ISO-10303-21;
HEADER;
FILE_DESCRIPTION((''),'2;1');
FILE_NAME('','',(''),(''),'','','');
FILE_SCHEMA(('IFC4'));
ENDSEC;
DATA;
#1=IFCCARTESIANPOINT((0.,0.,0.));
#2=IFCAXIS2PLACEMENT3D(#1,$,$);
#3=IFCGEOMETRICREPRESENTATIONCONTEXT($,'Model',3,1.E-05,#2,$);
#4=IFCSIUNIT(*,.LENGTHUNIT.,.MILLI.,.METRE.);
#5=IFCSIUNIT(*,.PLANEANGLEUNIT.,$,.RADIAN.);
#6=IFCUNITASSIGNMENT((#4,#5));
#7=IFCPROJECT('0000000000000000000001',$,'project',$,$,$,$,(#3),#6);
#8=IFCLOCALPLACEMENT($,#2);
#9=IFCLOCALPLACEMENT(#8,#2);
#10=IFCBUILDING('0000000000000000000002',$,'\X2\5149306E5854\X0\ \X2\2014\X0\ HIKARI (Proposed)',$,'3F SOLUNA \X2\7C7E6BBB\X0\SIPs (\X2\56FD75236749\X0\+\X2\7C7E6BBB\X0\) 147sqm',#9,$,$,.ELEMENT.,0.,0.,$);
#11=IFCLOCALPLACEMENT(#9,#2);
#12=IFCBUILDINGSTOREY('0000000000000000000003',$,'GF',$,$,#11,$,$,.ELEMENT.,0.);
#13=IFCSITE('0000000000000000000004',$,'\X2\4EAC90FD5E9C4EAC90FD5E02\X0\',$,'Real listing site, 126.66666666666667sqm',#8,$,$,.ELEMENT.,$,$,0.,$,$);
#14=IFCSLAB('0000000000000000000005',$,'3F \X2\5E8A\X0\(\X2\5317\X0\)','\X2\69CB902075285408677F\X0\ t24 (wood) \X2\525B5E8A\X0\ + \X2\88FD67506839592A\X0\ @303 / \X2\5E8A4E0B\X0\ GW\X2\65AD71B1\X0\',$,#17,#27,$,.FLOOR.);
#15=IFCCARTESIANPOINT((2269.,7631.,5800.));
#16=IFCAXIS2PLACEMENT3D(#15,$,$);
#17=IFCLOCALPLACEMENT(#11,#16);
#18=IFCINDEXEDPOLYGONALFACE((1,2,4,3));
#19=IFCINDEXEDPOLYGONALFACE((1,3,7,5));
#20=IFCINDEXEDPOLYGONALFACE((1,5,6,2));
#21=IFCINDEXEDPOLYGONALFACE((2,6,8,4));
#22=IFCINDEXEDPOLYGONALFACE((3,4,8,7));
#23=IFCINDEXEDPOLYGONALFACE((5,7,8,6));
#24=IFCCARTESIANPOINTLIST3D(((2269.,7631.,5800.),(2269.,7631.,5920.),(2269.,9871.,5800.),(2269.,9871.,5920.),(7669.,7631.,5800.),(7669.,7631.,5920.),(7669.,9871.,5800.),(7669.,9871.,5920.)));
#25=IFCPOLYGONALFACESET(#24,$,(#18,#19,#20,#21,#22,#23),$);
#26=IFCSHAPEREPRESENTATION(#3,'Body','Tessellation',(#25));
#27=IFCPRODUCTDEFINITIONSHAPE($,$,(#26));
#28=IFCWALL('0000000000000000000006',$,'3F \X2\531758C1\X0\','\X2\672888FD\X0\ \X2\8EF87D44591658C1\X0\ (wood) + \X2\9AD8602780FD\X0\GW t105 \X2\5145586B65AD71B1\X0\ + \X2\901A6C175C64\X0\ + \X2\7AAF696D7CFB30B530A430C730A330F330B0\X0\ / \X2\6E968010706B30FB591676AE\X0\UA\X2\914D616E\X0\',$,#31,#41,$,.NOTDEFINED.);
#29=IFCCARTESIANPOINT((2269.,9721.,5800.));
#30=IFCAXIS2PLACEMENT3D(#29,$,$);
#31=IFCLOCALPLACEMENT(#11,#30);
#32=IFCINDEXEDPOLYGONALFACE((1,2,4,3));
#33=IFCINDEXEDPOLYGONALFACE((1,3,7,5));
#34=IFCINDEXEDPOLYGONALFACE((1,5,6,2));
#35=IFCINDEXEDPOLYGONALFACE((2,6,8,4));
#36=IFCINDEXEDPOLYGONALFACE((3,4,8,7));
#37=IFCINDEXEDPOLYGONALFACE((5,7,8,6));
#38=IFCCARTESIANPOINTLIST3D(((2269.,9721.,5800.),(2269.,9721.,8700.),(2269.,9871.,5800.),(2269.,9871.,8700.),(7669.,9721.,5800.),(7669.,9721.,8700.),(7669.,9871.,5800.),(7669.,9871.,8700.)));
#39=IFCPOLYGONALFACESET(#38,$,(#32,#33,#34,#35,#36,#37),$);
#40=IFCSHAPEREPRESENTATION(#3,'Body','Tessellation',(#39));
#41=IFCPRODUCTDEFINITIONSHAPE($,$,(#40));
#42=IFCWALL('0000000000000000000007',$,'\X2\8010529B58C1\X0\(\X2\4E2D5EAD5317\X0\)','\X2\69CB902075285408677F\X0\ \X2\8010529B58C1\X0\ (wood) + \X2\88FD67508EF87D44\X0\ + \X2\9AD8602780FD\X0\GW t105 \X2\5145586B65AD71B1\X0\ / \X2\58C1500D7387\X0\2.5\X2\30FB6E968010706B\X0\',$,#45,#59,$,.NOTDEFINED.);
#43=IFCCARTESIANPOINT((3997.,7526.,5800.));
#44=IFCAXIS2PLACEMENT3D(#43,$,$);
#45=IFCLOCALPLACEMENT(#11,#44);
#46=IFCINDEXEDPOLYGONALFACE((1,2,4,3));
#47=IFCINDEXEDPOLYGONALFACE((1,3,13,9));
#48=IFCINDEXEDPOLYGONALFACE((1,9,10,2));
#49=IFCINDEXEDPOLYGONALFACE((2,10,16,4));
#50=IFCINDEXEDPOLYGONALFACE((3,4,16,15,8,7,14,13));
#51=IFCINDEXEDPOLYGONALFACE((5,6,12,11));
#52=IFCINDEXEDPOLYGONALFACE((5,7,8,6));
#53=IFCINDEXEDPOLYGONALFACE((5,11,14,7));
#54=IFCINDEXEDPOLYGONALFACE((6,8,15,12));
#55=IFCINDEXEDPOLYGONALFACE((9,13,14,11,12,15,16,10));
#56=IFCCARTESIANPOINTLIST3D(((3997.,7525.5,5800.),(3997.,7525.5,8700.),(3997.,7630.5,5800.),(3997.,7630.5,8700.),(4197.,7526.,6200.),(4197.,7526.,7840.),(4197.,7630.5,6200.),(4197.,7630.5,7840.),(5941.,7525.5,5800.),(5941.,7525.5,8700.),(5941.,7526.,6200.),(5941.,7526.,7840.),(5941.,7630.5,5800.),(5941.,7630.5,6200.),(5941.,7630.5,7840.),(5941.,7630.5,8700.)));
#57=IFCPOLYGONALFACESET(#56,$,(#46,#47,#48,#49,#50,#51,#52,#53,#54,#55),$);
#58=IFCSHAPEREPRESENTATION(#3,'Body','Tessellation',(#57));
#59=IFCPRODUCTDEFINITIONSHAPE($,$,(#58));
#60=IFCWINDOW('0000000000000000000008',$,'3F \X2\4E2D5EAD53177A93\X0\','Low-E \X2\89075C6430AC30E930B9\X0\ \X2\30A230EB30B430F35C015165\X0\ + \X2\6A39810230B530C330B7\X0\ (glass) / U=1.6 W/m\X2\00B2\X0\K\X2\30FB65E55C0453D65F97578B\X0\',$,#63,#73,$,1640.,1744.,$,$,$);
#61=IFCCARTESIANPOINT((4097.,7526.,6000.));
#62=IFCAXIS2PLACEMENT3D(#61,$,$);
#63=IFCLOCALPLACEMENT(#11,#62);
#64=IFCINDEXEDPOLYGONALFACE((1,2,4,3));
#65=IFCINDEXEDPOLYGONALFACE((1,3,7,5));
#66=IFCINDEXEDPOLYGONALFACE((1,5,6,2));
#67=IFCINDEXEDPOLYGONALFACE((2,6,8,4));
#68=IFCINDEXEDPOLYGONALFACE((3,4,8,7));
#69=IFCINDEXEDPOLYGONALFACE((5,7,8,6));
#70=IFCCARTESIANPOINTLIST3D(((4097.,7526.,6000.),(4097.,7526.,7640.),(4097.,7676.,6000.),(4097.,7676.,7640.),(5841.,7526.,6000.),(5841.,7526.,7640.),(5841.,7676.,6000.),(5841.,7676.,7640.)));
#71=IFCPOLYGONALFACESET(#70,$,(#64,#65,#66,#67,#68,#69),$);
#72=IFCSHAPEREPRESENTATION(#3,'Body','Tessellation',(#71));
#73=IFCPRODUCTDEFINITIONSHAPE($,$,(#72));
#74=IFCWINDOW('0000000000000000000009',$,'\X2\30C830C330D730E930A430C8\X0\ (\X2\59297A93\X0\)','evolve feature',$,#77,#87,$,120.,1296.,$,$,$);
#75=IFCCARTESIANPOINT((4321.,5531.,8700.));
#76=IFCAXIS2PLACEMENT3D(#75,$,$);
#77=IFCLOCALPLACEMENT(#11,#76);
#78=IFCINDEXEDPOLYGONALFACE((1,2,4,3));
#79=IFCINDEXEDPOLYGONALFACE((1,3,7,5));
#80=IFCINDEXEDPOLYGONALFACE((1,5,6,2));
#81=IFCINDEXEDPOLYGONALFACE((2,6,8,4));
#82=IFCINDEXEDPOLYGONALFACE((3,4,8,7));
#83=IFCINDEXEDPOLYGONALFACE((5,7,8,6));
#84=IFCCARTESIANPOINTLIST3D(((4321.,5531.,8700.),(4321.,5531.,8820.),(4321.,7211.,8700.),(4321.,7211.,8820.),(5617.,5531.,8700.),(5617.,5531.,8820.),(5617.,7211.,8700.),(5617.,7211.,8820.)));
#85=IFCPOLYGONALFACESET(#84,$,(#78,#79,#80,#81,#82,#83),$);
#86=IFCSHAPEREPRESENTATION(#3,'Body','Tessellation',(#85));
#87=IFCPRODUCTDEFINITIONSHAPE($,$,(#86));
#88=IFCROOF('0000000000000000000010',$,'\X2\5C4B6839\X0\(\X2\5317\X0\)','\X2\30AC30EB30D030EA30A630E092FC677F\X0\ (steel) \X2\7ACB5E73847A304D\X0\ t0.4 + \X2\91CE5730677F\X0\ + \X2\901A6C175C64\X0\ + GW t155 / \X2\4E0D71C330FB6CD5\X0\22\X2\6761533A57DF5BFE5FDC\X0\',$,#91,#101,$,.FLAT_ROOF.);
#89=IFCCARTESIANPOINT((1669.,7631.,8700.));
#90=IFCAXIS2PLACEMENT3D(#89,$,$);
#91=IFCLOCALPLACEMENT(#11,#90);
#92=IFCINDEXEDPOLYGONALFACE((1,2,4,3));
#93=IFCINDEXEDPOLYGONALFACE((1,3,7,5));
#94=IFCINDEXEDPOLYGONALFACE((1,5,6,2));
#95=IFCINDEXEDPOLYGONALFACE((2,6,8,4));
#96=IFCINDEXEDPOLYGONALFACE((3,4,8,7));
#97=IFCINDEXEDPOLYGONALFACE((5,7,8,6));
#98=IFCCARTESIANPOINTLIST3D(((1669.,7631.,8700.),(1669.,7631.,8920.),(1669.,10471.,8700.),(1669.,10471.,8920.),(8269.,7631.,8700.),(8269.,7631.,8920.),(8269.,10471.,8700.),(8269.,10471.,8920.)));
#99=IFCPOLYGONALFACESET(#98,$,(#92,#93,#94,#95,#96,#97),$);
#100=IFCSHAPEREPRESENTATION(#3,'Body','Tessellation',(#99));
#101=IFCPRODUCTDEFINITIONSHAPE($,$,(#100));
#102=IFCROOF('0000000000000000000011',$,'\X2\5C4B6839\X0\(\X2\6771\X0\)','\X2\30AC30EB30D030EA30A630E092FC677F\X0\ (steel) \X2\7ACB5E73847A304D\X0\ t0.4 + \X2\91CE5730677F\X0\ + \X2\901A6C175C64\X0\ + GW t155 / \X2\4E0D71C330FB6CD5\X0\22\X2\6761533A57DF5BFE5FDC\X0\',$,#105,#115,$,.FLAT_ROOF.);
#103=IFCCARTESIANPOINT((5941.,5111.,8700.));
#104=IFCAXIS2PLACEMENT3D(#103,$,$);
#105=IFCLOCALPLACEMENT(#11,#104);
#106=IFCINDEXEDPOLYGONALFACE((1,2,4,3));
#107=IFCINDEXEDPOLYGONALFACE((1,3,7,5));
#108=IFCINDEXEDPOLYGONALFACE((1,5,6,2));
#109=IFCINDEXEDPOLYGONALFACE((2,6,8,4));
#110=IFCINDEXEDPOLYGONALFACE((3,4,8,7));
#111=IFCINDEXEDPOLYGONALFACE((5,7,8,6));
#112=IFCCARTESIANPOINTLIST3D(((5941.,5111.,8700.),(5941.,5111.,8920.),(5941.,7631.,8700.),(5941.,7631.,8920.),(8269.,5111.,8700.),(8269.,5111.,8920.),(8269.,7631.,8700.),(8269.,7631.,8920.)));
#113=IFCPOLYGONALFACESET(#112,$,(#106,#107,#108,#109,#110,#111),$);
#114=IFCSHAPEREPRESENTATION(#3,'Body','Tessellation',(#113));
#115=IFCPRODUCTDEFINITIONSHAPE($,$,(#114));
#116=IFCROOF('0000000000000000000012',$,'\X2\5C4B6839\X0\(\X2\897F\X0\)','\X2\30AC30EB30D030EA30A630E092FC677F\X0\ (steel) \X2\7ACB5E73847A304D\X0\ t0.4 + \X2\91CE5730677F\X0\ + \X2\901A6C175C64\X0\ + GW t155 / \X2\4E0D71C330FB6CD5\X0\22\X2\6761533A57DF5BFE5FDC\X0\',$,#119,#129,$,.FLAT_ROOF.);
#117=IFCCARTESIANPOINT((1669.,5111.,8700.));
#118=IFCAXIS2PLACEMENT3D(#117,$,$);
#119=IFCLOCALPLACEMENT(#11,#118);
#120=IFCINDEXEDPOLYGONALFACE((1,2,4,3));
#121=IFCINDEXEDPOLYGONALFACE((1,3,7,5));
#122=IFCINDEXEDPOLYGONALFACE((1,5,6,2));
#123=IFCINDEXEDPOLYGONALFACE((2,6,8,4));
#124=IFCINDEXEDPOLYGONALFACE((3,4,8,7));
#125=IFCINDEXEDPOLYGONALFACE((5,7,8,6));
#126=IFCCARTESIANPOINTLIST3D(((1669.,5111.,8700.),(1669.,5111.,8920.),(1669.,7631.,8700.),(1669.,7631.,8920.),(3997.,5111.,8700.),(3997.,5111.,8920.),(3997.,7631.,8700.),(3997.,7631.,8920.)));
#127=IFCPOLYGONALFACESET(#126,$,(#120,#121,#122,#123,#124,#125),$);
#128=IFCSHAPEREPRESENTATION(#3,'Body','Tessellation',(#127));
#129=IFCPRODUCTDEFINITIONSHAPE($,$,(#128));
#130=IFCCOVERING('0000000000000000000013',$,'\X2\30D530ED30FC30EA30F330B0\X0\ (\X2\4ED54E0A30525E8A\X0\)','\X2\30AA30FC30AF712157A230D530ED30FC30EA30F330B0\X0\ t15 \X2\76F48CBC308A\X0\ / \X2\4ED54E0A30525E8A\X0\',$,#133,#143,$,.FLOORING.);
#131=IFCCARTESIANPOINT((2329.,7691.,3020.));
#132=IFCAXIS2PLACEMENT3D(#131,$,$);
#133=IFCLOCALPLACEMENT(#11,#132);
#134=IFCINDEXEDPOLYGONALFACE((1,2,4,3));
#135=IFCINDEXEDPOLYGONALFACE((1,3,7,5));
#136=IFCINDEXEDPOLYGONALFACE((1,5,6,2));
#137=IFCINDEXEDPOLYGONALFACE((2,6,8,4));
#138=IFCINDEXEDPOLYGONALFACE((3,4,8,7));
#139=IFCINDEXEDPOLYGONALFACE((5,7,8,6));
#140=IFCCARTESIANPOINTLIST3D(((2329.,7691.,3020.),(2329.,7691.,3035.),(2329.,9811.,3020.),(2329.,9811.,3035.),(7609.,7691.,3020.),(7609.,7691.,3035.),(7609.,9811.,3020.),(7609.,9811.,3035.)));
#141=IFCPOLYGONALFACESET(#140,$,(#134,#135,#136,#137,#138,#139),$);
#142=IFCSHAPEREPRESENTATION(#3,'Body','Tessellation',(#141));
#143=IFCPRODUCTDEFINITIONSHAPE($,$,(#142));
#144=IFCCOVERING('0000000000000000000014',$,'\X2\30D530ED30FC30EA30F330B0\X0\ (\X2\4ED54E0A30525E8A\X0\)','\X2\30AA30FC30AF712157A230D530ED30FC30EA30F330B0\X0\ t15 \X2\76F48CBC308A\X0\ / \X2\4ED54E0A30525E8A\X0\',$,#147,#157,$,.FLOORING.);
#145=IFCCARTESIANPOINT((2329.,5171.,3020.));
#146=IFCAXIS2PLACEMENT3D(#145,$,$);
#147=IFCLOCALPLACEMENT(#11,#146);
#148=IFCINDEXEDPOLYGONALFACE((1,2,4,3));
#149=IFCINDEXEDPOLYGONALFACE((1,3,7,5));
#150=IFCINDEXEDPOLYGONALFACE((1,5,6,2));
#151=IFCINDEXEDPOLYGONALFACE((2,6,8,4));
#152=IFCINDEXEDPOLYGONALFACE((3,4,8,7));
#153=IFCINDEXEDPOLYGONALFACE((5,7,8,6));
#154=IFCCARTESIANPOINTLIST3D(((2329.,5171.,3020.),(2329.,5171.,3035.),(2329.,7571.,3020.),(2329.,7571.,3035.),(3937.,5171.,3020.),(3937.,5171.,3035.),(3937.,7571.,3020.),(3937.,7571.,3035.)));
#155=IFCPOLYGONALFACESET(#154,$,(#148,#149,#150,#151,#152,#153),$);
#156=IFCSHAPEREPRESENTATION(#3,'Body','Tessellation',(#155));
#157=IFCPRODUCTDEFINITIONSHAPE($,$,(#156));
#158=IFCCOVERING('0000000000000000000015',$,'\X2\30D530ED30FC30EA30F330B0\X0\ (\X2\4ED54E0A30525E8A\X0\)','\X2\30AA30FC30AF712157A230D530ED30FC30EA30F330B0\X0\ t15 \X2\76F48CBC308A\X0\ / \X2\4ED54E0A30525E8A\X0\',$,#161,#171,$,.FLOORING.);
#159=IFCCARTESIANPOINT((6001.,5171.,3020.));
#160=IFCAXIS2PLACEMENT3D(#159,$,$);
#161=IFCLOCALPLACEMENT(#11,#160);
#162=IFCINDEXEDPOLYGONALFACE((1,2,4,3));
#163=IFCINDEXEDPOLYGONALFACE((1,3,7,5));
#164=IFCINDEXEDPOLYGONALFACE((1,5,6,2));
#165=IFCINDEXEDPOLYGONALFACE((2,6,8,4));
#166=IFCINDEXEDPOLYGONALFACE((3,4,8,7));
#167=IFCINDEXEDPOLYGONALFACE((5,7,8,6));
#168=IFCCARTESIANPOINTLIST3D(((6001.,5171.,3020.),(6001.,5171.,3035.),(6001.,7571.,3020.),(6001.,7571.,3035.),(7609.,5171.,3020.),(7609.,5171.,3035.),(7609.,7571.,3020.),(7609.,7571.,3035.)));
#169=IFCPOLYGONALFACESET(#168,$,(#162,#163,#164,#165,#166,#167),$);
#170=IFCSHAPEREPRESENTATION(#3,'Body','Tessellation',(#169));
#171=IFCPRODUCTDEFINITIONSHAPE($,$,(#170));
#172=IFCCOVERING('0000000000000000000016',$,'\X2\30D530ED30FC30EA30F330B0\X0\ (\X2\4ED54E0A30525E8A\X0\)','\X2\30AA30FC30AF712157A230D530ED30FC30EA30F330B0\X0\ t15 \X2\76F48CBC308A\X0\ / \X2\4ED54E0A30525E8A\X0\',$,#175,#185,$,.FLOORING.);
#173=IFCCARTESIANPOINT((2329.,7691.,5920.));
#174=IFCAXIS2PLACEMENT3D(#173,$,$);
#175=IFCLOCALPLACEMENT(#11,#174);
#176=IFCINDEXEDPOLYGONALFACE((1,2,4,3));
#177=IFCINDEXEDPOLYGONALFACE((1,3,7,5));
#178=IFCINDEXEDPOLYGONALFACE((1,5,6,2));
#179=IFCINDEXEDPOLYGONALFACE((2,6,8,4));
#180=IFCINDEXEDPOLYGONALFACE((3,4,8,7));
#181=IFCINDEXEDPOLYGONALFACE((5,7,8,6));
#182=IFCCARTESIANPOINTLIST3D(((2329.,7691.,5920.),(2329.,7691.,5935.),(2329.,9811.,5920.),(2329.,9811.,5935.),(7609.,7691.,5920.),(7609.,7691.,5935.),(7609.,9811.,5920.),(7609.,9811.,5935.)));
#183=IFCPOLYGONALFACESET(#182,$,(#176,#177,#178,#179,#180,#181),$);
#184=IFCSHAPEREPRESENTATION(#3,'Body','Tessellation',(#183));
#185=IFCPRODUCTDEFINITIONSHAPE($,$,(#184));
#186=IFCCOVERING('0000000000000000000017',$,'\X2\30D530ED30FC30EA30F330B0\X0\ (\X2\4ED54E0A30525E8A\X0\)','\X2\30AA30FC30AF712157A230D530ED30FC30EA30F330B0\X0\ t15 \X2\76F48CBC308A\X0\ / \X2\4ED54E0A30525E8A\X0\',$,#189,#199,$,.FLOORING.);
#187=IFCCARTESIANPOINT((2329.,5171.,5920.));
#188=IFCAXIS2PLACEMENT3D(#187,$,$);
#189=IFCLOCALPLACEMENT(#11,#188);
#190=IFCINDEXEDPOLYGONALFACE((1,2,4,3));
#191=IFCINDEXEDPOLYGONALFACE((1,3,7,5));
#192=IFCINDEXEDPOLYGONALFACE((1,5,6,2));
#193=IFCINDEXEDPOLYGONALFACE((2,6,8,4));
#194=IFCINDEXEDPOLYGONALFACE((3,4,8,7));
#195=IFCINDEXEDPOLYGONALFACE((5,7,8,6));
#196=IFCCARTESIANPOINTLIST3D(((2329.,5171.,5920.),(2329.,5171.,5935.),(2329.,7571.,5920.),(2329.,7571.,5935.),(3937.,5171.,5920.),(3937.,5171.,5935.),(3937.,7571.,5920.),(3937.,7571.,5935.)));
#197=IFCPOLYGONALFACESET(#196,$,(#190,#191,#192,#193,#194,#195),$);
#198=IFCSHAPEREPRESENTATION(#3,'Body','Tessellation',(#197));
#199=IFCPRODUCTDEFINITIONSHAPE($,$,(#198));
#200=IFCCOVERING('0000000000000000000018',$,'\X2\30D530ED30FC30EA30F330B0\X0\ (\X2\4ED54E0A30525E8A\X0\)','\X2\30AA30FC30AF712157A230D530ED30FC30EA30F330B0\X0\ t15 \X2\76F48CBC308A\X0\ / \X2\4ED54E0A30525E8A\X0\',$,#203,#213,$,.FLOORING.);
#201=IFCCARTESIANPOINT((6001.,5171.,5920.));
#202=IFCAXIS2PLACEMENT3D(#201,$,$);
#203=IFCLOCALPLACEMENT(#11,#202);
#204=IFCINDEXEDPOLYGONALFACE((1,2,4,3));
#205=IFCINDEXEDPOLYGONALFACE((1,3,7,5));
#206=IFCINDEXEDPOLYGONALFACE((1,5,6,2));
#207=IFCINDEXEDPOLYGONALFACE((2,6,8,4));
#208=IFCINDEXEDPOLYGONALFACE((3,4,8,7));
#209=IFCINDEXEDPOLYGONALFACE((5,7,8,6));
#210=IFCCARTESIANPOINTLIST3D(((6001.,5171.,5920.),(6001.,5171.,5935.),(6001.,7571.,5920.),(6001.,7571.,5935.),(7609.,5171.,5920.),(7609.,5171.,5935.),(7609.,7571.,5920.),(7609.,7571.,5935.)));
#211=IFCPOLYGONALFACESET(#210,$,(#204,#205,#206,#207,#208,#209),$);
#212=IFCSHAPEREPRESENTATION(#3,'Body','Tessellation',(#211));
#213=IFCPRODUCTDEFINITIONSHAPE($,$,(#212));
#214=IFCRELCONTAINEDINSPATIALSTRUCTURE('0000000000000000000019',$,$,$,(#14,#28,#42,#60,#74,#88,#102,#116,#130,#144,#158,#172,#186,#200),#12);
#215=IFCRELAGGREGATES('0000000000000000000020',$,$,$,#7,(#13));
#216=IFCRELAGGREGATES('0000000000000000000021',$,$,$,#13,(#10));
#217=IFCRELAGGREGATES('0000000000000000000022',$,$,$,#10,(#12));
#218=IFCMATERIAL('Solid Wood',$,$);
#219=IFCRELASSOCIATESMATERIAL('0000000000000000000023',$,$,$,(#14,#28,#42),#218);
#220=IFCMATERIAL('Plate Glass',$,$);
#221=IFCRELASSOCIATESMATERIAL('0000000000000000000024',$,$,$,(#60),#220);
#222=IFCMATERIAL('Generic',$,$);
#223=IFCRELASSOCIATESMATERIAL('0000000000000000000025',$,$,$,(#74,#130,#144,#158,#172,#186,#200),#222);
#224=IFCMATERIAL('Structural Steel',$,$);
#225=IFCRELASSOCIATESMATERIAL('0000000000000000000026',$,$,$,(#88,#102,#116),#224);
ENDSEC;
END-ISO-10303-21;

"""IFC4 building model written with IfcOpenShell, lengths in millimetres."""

from ifc_helpers import new_model, si_unit, frame, frame_2d, origin, place, context, project, spatial, rectangle, extrude, material, element, fill, save


model = new_model("IFC4")

# Units and contexts
model_context = context("Model", 3, precision=1e-05, world=origin())
ifc_project = project(units=[si_unit("LENGTHUNIT", "METRE", prefix="MILLI"), si_unit("PLANEANGLEUNIT", "RADIAN")], contexts=[model_context])

# Site, building, storey
site_placement = place(None, origin())
site = spatial("IfcSite", under=ifc_project, at=site_placement, Name="京都府京都市", ObjectType="Real listing site, 126.66666666666667sqm", CompositionType="ELEMENT", RefElevation=0.0)
building_placement = place(site_placement, origin())
building = spatial("IfcBuilding", under=site, at=building_placement, Name="光の塔 — HIKARI (Proposed)", ObjectType="3F SOLUNA 籾殻SIPs (国産杉+籾殻) 147sqm", CompositionType="ELEMENT", ElevationOfRefHeight=0.0, ElevationOfTerrain=0.0)
storey_placement = place(building_placement, origin())
storey = spatial("IfcBuildingStorey", under=building, at=storey_placement, Name="GF", CompositionType="ELEMENT", Elevation=0.0)

# Slab
ifc_material_1 = material(Name="Solid Wood")
slab_placement = place(storey_placement, frame((2269.0, 7631.0, 5800.0)))
element("IfcSlab", 1, at=slab_placement, inside=storey, material=ifc_material_1, Name="3F 床(北)", Description="構造用合板 t24 (wood) 剛床 + 製材根太 @303 / 床下 GW断熱", PredefinedType="FLOOR", context=model_context, shape_type="SweptSolid", body=[
    extrude(rectangle(XDim=5400.0, YDim=2240.0, at=frame_2d((2700.0, 1120.0))), frame((2269.0, 7631.0, 5800.0)), (0.0, 0.0, 1.0), 120.0),
])

# Wall
wall_1_placement = place(storey_placement, frame((2269.0, 9721.0, 5800.0)))
element("IfcWall", 2, at=wall_1_placement, inside=storey, material=ifc_material_1, Name="3F 北壁", Description="木製 軸組外壁 (wood) + 高性能GW t105 充填断熱 + 通気層 + 窯業系サイディング / 準耐火・外皮UA配慮", PredefinedType="NOTDEFINED", context=model_context, shape_type="SweptSolid", body=[
    extrude(rectangle(XDim=5400.0, YDim=150.0, at=frame_2d((2700.0, 75.0))), frame((2269.0, 9721.0, 5800.0)), (0.0, 0.0, 1.0), 2900.0),
])

# Wall, opening, window
wall_2_placement = place(storey_placement, frame((3997.0, 7526.0, 5800.0)))
wall_2 = element("IfcWall", 3, at=wall_2_placement, inside=storey, material=ifc_material_1, Name="耐力壁(中庭北)", Description="構造用合板 耐力壁 (wood) + 製材軸組 + 高性能GW t105 充填断熱 / 壁倍率2.5・準耐火", PredefinedType="NOTDEFINED", context=model_context, shape_type="SweptSolid", body=[
    extrude(rectangle(XDim=1944.0, YDim=105.0, at=frame_2d((972.0, 52.0))), frame((3997.0, 7526.0, 5800.0)), (0.0, 0.0, 1.0), 2900.0),
])
opening_placement = place(storey_placement, frame((4097.0, 7526.0, 6000.0)))
opening = element("IfcOpeningElement", 4, at=opening_placement, cuts=wall_2, PredefinedType="NOTDEFINED", context=model_context, shape_type="SweptSolid", body=[
    extrude(rectangle(XDim=1744.0, YDim=150.0, at=frame_2d((872.0, 75.0))), frame((4097.0, 7526.0, 6000.0)), (0.0, 0.0, 1.0), 1640.0),
])
ifc_material_2 = material(Name="Plate Glass")
window_1_placement = place(storey_placement, frame((4097.0, 7526.0, 6000.0)))
window_1 = element("IfcWindow", 5, at=window_1_placement, inside=storey, material=ifc_material_2, Name="3F 中庭北窓", Description="Low-E 複層ガラス アルゴン封入 + 樹脂サッシ (glass) / U=1.6 W/m²K・日射取得型", OverallHeight=1640.0, OverallWidth=1744.0, context=model_context, shape_type="SweptSolid", body=[
    extrude(rectangle(XDim=1744.0, YDim=150.0, at=frame_2d((872.0, 75.0))), frame((4097.0, 7526.0, 6000.0)), (0.0, 0.0, 1.0), 1640.0),
])
fill(opening, window_1)

# Window
ifc_material_3 = material(Name="Generic")
window_2_placement = place(storey_placement, frame((4321.0, 5531.0, 8700.0)))
element("IfcWindow", 6, at=window_2_placement, inside=storey, material=ifc_material_3, Name="トップライト (天窓)", Description="evolve feature", OverallHeight=120.0, OverallWidth=1296.0, context=model_context, shape_type="SweptSolid", body=[
    extrude(rectangle(XDim=1296.0, YDim=1680.0, at=frame_2d((648.0, 840.0))), frame((4321.0, 5531.0, 8700.0)), (0.0, 0.0, 1.0), 120.0),
])

# Roofs
ifc_material_4 = material(Name="Structural Steel")
roof_1_placement = place(storey_placement, frame((1669.0, 7631.0, 8700.0)))
element("IfcRoof", 7, at=roof_1_placement, inside=storey, material=ifc_material_4, Name="屋根(北)", Description="ガルバリウム鋼板 (steel) 立平葺き t0.4 + 野地板 + 通気層 + GW t155 / 不燃・法22条区域対応", PredefinedType="FLAT_ROOF", context=model_context, shape_type="SweptSolid", body=[
    extrude(rectangle(XDim=6600.0, YDim=2840.0, at=frame_2d((3300.0, 1420.0))), frame((1669.0, 7631.0, 8700.0)), (0.0, 0.0, 1.0), 220.0),
])
roof_2_placement = place(storey_placement, frame((5941.0, 5111.0, 8700.0)))
element("IfcRoof", 8, at=roof_2_placement, inside=storey, material=ifc_material_4, Name="屋根(東)", Description="ガルバリウム鋼板 (steel) 立平葺き t0.4 + 野地板 + 通気層 + GW t155 / 不燃・法22条区域対応", PredefinedType="FLAT_ROOF", context=model_context, shape_type="SweptSolid", body=[
    extrude(rectangle(XDim=2328.0, YDim=2520.0, at=frame_2d((1164.0, 1260.0))), frame((5941.0, 5111.0, 8700.0)), (0.0, 0.0, 1.0), 220.0),
])
roof_3_placement = place(storey_placement, frame((1669.0, 5111.0, 8700.0)))
element("IfcRoof", 9, at=roof_3_placement, inside=storey, material=ifc_material_4, Name="屋根(西)", Description="ガルバリウム鋼板 (steel) 立平葺き t0.4 + 野地板 + 通気層 + GW t155 / 不燃・法22条区域対応", PredefinedType="FLAT_ROOF", context=model_context, shape_type="SweptSolid", body=[
    extrude(rectangle(XDim=2328.0, YDim=2520.0, at=frame_2d((1164.0, 1260.0))), frame((1669.0, 5111.0, 8700.0)), (0.0, 0.0, 1.0), 220.0),
])

# Coverings
covering_1_placement = place(storey_placement, frame((2329.0, 7691.0, 3020.0)))
element("IfcCovering", 10, at=covering_1_placement, inside=storey, material=ifc_material_3, Name="フローリング (仕上げ床)", Description="オーク無垢フローリング t15 直貼り / 仕上げ床", PredefinedType="FLOORING", context=model_context, shape_type="SweptSolid", body=[
    extrude(rectangle(XDim=5280.0, YDim=2120.0, at=frame_2d((2640.0, 1060.0))), frame((2329.0, 7691.0, 3020.0)), (0.0, 0.0, 1.0), 15.0),
])
covering_2_placement = place(storey_placement, frame((2329.0, 5171.0, 3020.0)))
element("IfcCovering", 11, at=covering_2_placement, inside=storey, material=ifc_material_3, Name="フローリング (仕上げ床)", Description="オーク無垢フローリング t15 直貼り / 仕上げ床", PredefinedType="FLOORING", context=model_context, shape_type="SweptSolid", body=[
    extrude(rectangle(XDim=1608.0, YDim=2400.0, at=frame_2d((804.0, 1200.0))), frame((2329.0, 5171.0, 3020.0)), (0.0, 0.0, 1.0), 15.0),
])
covering_3_placement = place(storey_placement, frame((6001.0, 5171.0, 3020.0)))
element("IfcCovering", 12, at=covering_3_placement, inside=storey, material=ifc_material_3, Name="フローリング (仕上げ床)", Description="オーク無垢フローリング t15 直貼り / 仕上げ床", PredefinedType="FLOORING", context=model_context, shape_type="SweptSolid", body=[
    extrude(rectangle(XDim=1608.0, YDim=2400.0, at=frame_2d((804.0, 1200.0))), frame((6001.0, 5171.0, 3020.0)), (0.0, 0.0, 1.0), 15.0),
])
covering_4_placement = place(storey_placement, frame((2329.0, 7691.0, 5920.0)))
element("IfcCovering", 13, at=covering_4_placement, inside=storey, material=ifc_material_3, Name="フローリング (仕上げ床)", Description="オーク無垢フローリング t15 直貼り / 仕上げ床", PredefinedType="FLOORING", context=model_context, shape_type="SweptSolid", body=[
    extrude(rectangle(XDim=5280.0, YDim=2120.0, at=frame_2d((2640.0, 1060.0))), frame((2329.0, 7691.0, 5920.0)), (0.0, 0.0, 1.0), 15.0),
])
covering_5_placement = place(storey_placement, frame((2329.0, 5171.0, 5920.0)))
element("IfcCovering", 14, at=covering_5_placement, inside=storey, material=ifc_material_3, Name="フローリング (仕上げ床)", Description="オーク無垢フローリング t15 直貼り / 仕上げ床", PredefinedType="FLOORING", context=model_context, shape_type="SweptSolid", body=[
    extrude(rectangle(XDim=1608.0, YDim=2400.0, at=frame_2d((804.0, 1200.0))), frame((2329.0, 5171.0, 5920.0)), (0.0, 0.0, 1.0), 15.0),
])
covering_6_placement = place(storey_placement, frame((6001.0, 5171.0, 5920.0)))
element("IfcCovering", 15, at=covering_6_placement, inside=storey, material=ifc_material_3, Name="フローリング (仕上げ床)", Description="オーク無垢フローリング t15 直貼り / 仕上げ床", PredefinedType="FLOORING", context=model_context, shape_type="SweptSolid", body=[
    extrude(rectangle(XDim=1608.0, YDim=2400.0, at=frame_2d((804.0, 1200.0))), frame((6001.0, 5171.0, 5920.0)), (0.0, 0.0, 1.0), 15.0),
])

save(model, "model.ifc")
